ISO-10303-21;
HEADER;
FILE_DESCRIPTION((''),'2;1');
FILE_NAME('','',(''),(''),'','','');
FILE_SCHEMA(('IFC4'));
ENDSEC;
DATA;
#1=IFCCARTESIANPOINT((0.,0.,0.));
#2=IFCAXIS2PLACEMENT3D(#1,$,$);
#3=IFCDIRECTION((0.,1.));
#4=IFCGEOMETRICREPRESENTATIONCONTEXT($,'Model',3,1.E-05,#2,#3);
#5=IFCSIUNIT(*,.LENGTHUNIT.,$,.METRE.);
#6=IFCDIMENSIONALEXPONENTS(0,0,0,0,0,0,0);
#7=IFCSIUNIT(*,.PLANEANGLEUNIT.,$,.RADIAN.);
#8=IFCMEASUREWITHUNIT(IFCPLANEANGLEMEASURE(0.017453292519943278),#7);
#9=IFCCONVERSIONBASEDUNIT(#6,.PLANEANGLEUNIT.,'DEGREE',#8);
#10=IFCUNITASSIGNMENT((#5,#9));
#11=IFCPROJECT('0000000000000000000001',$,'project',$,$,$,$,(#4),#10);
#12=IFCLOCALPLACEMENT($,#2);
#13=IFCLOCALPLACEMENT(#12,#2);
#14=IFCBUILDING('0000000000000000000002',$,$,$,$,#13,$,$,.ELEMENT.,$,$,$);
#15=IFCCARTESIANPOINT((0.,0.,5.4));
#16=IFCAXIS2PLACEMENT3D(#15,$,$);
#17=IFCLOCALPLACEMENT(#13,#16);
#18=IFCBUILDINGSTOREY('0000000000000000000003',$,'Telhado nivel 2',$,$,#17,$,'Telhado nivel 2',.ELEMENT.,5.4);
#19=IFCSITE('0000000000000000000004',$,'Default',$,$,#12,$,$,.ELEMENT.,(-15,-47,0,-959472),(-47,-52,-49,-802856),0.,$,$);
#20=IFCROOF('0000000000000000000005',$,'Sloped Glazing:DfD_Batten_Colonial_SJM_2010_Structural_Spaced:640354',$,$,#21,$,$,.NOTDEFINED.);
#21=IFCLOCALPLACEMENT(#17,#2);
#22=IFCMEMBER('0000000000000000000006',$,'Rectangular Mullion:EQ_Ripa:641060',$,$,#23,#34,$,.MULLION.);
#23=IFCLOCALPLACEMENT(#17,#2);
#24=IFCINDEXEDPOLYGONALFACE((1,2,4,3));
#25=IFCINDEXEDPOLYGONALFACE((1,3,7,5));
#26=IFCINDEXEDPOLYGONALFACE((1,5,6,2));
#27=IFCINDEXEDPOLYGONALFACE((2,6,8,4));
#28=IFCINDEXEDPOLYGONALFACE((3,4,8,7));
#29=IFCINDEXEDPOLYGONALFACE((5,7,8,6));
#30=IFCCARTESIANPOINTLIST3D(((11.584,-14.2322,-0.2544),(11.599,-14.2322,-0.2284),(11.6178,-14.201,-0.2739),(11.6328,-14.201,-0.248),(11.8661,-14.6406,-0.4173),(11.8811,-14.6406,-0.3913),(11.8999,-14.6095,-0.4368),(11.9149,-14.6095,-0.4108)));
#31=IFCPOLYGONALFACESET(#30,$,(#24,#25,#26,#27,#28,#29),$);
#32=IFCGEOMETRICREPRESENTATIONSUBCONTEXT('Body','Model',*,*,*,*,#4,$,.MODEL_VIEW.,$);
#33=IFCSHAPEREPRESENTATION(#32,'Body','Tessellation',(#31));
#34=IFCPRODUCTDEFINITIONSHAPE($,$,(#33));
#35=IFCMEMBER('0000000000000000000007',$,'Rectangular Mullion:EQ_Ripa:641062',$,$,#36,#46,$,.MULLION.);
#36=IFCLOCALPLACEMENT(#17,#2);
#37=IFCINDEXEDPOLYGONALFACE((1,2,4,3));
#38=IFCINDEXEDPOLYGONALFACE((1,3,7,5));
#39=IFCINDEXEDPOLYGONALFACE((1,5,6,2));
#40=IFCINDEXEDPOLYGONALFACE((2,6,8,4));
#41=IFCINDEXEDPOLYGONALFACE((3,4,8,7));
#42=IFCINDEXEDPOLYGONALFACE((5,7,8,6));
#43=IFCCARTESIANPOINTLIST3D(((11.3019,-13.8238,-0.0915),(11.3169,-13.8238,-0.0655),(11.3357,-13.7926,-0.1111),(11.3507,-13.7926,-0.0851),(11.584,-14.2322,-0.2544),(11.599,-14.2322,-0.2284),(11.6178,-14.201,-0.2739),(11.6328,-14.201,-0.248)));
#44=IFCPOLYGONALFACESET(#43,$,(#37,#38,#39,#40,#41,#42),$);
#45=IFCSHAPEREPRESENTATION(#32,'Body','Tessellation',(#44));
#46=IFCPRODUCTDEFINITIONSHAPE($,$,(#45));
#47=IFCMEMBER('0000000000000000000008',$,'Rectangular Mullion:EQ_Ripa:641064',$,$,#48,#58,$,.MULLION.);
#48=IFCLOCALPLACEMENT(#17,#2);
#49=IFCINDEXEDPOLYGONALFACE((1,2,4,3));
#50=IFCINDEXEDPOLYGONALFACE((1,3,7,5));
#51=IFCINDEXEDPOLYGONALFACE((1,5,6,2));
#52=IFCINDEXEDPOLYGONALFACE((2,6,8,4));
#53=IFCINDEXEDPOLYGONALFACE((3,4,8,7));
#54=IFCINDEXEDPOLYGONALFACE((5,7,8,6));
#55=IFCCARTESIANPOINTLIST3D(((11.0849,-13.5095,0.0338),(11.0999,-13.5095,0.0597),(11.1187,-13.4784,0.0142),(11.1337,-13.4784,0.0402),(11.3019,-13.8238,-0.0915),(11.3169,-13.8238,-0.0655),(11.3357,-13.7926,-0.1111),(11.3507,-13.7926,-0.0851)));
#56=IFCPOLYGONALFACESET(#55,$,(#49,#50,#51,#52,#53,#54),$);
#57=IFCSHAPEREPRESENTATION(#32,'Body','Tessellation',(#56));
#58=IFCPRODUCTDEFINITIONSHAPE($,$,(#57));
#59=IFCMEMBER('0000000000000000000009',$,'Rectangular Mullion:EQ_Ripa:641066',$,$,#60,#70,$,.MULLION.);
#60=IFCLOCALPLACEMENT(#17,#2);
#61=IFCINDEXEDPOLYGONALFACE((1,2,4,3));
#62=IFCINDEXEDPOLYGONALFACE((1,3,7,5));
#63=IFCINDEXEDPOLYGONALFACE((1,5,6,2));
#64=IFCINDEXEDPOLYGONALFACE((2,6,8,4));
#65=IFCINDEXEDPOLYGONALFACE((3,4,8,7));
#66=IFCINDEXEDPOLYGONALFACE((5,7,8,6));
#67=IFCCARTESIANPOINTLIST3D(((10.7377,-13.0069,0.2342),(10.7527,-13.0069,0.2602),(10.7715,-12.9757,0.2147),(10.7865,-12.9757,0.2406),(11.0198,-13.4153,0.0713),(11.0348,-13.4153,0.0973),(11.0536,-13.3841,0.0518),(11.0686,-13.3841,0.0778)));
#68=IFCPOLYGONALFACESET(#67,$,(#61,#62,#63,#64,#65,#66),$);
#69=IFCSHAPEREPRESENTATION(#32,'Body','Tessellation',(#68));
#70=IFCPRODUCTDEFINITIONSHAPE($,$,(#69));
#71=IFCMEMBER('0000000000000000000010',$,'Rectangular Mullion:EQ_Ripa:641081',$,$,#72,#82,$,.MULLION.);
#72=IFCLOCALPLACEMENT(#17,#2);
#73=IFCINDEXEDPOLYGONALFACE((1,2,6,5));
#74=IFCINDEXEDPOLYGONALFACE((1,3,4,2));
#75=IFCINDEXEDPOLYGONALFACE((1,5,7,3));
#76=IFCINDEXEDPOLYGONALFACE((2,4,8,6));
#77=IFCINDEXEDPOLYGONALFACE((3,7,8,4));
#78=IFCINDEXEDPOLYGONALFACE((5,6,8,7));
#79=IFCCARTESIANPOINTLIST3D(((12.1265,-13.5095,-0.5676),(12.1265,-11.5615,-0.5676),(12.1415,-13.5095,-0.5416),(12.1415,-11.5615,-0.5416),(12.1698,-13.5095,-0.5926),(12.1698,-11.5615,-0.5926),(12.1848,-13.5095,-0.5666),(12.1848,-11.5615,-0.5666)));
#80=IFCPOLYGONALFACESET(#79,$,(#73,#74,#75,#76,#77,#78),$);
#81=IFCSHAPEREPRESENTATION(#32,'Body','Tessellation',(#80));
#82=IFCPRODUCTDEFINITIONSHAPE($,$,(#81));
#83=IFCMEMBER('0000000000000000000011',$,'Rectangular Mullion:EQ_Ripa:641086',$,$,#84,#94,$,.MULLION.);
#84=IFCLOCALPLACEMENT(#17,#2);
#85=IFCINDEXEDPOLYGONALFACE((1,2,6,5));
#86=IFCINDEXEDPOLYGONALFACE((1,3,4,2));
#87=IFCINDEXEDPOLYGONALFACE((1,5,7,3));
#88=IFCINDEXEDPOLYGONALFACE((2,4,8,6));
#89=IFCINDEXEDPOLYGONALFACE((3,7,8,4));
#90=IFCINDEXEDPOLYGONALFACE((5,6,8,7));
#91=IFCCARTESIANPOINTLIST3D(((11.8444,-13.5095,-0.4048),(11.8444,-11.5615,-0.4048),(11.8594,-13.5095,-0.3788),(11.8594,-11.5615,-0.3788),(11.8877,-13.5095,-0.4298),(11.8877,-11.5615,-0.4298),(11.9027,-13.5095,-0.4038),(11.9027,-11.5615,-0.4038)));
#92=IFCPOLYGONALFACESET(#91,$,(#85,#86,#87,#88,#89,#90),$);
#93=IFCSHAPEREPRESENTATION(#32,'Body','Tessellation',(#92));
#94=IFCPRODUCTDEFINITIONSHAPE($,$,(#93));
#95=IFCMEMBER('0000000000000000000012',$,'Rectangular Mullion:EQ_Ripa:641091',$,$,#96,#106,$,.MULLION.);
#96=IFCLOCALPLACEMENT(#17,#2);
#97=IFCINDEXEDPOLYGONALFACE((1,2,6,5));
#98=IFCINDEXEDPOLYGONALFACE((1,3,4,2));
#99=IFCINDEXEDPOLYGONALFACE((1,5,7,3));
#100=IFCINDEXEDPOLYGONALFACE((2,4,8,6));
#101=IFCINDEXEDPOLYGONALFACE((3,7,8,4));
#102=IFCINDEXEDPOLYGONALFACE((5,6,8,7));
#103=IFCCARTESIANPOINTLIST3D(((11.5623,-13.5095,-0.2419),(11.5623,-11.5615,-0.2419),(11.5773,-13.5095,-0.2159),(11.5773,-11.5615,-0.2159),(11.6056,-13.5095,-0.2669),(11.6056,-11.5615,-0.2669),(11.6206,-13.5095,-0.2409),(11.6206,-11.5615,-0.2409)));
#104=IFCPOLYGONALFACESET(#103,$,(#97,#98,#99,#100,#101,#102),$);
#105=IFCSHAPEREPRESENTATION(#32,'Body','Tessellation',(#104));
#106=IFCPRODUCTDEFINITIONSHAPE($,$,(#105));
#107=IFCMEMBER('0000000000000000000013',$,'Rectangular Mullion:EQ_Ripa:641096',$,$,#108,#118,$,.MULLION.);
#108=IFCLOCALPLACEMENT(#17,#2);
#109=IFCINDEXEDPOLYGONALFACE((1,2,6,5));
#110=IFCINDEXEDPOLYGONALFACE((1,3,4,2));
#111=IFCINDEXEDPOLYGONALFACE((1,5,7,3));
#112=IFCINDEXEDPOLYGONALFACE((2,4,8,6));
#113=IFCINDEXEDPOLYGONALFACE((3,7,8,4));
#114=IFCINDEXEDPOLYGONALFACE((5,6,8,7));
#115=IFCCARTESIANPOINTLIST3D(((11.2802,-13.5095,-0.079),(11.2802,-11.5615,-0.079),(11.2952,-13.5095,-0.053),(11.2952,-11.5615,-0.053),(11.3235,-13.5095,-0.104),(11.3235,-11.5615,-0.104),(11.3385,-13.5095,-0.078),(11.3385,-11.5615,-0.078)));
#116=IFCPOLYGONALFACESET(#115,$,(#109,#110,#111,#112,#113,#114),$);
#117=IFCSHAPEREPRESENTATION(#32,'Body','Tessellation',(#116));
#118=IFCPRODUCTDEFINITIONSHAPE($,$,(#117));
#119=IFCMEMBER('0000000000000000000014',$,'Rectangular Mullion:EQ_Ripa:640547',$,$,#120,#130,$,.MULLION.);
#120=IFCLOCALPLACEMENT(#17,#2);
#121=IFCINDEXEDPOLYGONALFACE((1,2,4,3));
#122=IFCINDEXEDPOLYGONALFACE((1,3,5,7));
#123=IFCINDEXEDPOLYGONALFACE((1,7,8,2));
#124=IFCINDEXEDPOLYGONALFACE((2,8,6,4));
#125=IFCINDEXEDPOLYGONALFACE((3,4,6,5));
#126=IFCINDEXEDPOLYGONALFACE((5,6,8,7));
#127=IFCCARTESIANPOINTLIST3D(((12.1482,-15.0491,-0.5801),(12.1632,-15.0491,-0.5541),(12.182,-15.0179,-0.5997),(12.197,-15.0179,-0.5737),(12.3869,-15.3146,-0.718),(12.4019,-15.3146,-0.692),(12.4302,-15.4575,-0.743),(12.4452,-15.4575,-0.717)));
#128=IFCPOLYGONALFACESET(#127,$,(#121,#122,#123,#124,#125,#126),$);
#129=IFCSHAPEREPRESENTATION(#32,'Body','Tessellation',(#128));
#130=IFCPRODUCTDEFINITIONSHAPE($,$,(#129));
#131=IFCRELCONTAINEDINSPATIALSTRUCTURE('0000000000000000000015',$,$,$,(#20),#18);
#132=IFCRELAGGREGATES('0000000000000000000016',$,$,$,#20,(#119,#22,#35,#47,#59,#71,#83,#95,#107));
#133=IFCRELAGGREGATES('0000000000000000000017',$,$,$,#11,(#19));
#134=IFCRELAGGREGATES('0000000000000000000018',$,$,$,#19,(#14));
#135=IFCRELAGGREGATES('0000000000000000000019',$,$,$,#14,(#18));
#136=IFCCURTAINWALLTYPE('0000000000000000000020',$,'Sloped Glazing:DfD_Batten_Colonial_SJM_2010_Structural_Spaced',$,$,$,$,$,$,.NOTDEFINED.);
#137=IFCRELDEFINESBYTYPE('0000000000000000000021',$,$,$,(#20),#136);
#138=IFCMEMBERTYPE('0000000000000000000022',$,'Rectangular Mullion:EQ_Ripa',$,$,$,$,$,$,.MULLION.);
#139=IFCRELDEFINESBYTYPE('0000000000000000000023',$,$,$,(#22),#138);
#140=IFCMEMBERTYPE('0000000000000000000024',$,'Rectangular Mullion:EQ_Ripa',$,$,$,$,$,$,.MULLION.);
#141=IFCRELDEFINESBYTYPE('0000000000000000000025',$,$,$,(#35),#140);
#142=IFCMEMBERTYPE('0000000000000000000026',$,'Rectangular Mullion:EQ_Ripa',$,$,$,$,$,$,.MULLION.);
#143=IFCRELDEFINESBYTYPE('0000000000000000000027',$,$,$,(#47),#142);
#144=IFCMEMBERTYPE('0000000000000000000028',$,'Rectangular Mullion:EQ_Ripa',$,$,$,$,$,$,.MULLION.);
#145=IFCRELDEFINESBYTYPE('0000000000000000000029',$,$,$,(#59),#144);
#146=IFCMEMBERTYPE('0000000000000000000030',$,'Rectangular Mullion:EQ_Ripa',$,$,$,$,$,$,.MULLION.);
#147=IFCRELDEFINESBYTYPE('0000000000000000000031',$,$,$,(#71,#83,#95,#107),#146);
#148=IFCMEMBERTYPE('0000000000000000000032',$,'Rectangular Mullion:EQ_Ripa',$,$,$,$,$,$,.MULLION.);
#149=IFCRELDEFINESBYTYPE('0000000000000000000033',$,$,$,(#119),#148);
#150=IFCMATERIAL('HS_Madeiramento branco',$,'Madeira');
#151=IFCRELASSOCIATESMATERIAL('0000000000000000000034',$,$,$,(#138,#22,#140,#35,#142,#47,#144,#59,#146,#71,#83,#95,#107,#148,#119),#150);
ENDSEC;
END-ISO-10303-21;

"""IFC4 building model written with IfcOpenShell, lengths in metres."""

from ifc_helpers import new_model, entity, si_unit, converted_unit, direction, frame, origin, place, context, subcontext, project, spatial, indexed_curve, outline, extrude, source, transform, mapped, material, type_object, type_shapes, element, aggregate, save


model = new_model("IFC4")

# Units and contexts
model_context = context("Model", 3, precision=1e-05, world=origin(), true_north=direction((0.0, 1.0)))
body_context = subcontext(model_context, "Body", "Model", "MODEL_VIEW")
ifc_project = project(units=[si_unit("LENGTHUNIT", "METRE"), converted_unit("PLANEANGLEUNIT", "DEGREE", entity("IfcPlaneAngleMeasure", 0.017453292519943278), si_unit("PLANEANGLEUNIT", "RADIAN"), dimensions=[0, 0, 0, 0, 0, 0, 0])], contexts=[model_context])

# Site, building, storey
site_placement = place(None, origin())
site = spatial("IfcSite", under=ifc_project, at=site_placement, Name="Default", CompositionType="ELEMENT", RefLatitude=(-15, -47, 0, -959472), RefLongitude=(-47, -52, -49, -802856), RefElevation=0.0)
building_placement = place(site_placement, origin())
building = spatial("IfcBuilding", under=site, at=building_placement, CompositionType="ELEMENT")
storey_placement = place(building_placement, frame((0.0, 0.0, 5.4)))
storey = spatial("IfcBuildingStorey", under=building, at=storey_placement, Name="Telhado nivel 2", LongName="Telhado nivel 2", CompositionType="ELEMENT", Elevation=5.4)

# Roof, members
ifc_material = material(Name="HS_Madeiramento branco", Category="Madeira")
curtain_wall_type_1 = type_object("IfcCurtainWallType", Name="Sloped Glazing:DfD_Batten_Colonial_SJM_2010_Structural_Spaced", PredefinedType="NOTDEFINED")
roof_1_placement = place(storey_placement, frame((0.0, 0.0, -5.4)))
roof_1 = element("IfcRoof", 1, at=roof_1_placement, inside=storey, type_object=curtain_wall_type_1, Name="Sloped Glazing:DfD_Batten_Colonial_SJM_2010_Structural_Spaced:640354", PredefinedType="NOTDEFINED")
member_type_1 = type_object("IfcMemberType", Name="Rectangular Mullion:EQ_Ripa", PredefinedType="MULLION", material=ifc_material)
shared_shape_1 = source(origin(), body_context, "Body", "SweptSolid", [
    extrude(outline(indexed_curve([(-0.025, -0.015), (0.025, -0.015), (0.025, 0.015), (-0.025, 0.015), (-0.025, -0.015)], self_intersect=False)), frame((-0.025, 0.0, -0.5224), z_axis=(0.0, 0.0, 1.0), x_axis=(-1.0, 0.0, 0.0)), (0.0, 0.0, 1.0), 0.5224),
])
type_shapes(member_type_1, [shared_shape_1])
member_1_placement = place(roof_1_placement, frame((11.8736, -14.6406, 4.9957), z_axis=(0.539965, -0.781825, -0.311749), x_axis=(-0.67708, -0.623498, 0.390913)))
member_1 = element("IfcMember", 2, at=member_1_placement, type_object=member_type_1, material=ifc_material, Name="Rectangular Mullion:EQ_Ripa:641060", PredefinedType="MULLION", context=body_context, shape_type="MappedRepresentation", body=[
    mapped(shared_shape_1, transform((0.0, 0.0, 0.0), scale=1.0)),
])
member_type_2 = type_object("IfcMemberType", Name="Rectangular Mullion:EQ_Ripa", PredefinedType="MULLION", material=ifc_material)
shared_shape_2 = source(origin(), body_context, "Body", "SweptSolid", [
    extrude(outline(indexed_curve([(-0.025, -0.015), (0.025, -0.015), (0.025, 0.015), (-0.025, 0.015), (-0.025, -0.015)], self_intersect=False)), frame((-0.025, 0.0, -0.5224), z_axis=(0.0, 0.0, 1.0), x_axis=(-1.0, 0.0, 0.0)), (0.0, 0.0, 1.0), 0.5224),
])
type_shapes(member_type_2, [shared_shape_2])
member_2_placement = place(roof_1_placement, frame((11.5915, -14.2322, 5.1586), z_axis=(0.539965, -0.781825, -0.311749), x_axis=(-0.67708, -0.623498, 0.390913)))
member_2 = element("IfcMember", 3, at=member_2_placement, type_object=member_type_2, material=ifc_material, Name="Rectangular Mullion:EQ_Ripa:641062", PredefinedType="MULLION", context=body_context, shape_type="MappedRepresentation", body=[
    mapped(shared_shape_2, transform((0.0, 0.0, 0.0), scale=1.0)),
])
member_type_3 = type_object("IfcMemberType", Name="Rectangular Mullion:EQ_Ripa", PredefinedType="MULLION", material=ifc_material)
shared_shape_3 = source(origin(), body_context, "Body", "SweptSolid", [
    extrude(outline(indexed_curve([(-0.025, -0.015), (0.025, -0.015), (0.025, 0.015), (-0.025, 0.015), (-0.025, -0.015)], self_intersect=False)), frame((-0.025, 0.0, -0.4019), z_axis=(0.0, 0.0, 1.0), x_axis=(-1.0, 0.0, 0.0)), (0.0, 0.0, 1.0), 0.4019),
])
type_shapes(member_type_3, [shared_shape_3])
member_3_placement = place(roof_1_placement, frame((11.3094, -13.8238, 5.3215), z_axis=(0.539965, -0.781825, -0.311749), x_axis=(-0.67708, -0.623498, 0.390913)))
member_3 = element("IfcMember", 4, at=member_3_placement, type_object=member_type_3, material=ifc_material, Name="Rectangular Mullion:EQ_Ripa:641064", PredefinedType="MULLION", context=body_context, shape_type="MappedRepresentation", body=[
    mapped(shared_shape_3, transform((0.0, 0.0, 0.0), scale=1.0)),
])
member_type_4 = type_object("IfcMemberType", Name="Rectangular Mullion:EQ_Ripa", PredefinedType="MULLION", material=ifc_material)
shared_shape_4 = source(origin(), body_context, "Body", "SweptSolid", [
    extrude(outline(indexed_curve([(-0.025, -0.015), (0.025, -0.015), (0.025, 0.015), (-0.025, 0.015), (-0.025, -0.015)], self_intersect=False)), frame((-0.025, 0.0, -0.5224), z_axis=(0.0, 0.0, 1.0), x_axis=(-1.0, 0.0, 0.0)), (0.0, 0.0, 1.0), 0.5224),
])
type_shapes(member_type_4, [shared_shape_4])
member_4_placement = place(roof_1_placement, frame((11.0273, -13.4153, 5.4843), z_axis=(0.539965, -0.781825, -0.311749), x_axis=(-0.67708, -0.623498, 0.390913)))
member_4 = element("IfcMember", 5, at=member_4_placement, type_object=member_type_4, material=ifc_material, Name="Rectangular Mullion:EQ_Ripa:641066", PredefinedType="MULLION", context=body_context, shape_type="MappedRepresentation", body=[
    mapped(shared_shape_4, transform((0.0, 0.0, 0.0), scale=1.0)),
])
member_type_5 = type_object("IfcMemberType", Name="Rectangular Mullion:EQ_Ripa", PredefinedType="MULLION", material=ifc_material)
shared_shape_5 = source(origin(), body_context, "Body", "SweptSolid", [
    extrude(outline(indexed_curve([(-0.025, -0.015), (0.025, -0.015), (0.025, 0.015), (-0.025, 0.015), (-0.025, -0.015)], self_intersect=False)), frame((0.0, 0.0, -1.948), z_axis=(0.0, 0.0, 1.0), x_axis=(-1.0, 0.0, 0.0)), (0.0, 0.0, 1.0), 1.948),
])
type_shapes(member_type_5, [shared_shape_5])
member_5_placement = place(roof_1_placement, frame((12.1557, -13.5095, 4.8329), z_axis=(0.0, -1.0, 0.0), x_axis=(-0.866025, 0.0, 0.5)))
member_5 = element("IfcMember", 6, at=member_5_placement, type_object=member_type_5, material=ifc_material, Name="Rectangular Mullion:EQ_Ripa:641081", PredefinedType="MULLION", context=body_context, shape_type="MappedRepresentation", body=[
    mapped(shared_shape_5, transform((0.0, 0.0, 0.0), scale=1.0)),
])
member_6_placement = place(roof_1_placement, frame((11.8736, -13.5095, 4.9957), z_axis=(0.0, -1.0, 0.0), x_axis=(-0.866025, 0.0, 0.5)))
member_6 = element("IfcMember", 7, at=member_6_placement, type_object=member_type_5, material=ifc_material, Name="Rectangular Mullion:EQ_Ripa:641086", PredefinedType="MULLION", context=body_context, shape_type="MappedRepresentation", body=[
    mapped(shared_shape_5, transform((0.0, 0.0, 0.0), scale=1.0)),
])
member_7_placement = place(roof_1_placement, frame((11.5915, -13.5095, 5.1586), z_axis=(0.0, -1.0, 0.0), x_axis=(-0.866025, 0.0, 0.5)))
member_7 = element("IfcMember", 8, at=member_7_placement, type_object=member_type_5, material=ifc_material, Name="Rectangular Mullion:EQ_Ripa:641091", PredefinedType="MULLION", context=body_context, shape_type="MappedRepresentation", body=[
    mapped(shared_shape_5, transform((0.0, 0.0, 0.0), scale=1.0)),
])
member_8_placement = place(roof_1_placement, frame((11.3094, -13.5095, 5.3215), z_axis=(0.0, -1.0, 0.0), x_axis=(-0.866025, 0.0, 0.5)))
member_8 = element("IfcMember", 9, at=member_8_placement, type_object=member_type_5, material=ifc_material, Name="Rectangular Mullion:EQ_Ripa:641096", PredefinedType="MULLION", context=body_context, shape_type="MappedRepresentation", body=[
    mapped(shared_shape_5, transform((0.0, 0.0, 0.0), scale=1.0)),
])
member_type_6 = type_object("IfcMemberType", Name="Rectangular Mullion:EQ_Ripa", PredefinedType="MULLION", material=ifc_material)
shared_shape_6 = source(origin(), body_context, "Body", "SweptSolid", [
    extrude(outline(indexed_curve([(-0.2969, -0.025), (0.2255, -0.025), (0.2255, 0.025), (-0.154, 0.025), (-0.2969, -0.025)], self_intersect=False)), frame((-0.025, -0.015, -0.2969), z_axis=(0.0, 1.0, 0.0), x_axis=(0.0, 0.0, -1.0)), (0.0, 0.0, 1.0), 0.03),
])
type_shapes(member_type_6, [shared_shape_6])
member_9_placement = place(roof_1_placement, frame((12.4377, -15.4575, 4.67), z_axis=(0.539965, -0.781825, -0.311749), x_axis=(-0.67708, -0.623498, 0.390913)))
member_9 = element("IfcMember", 10, at=member_9_placement, type_object=member_type_6, material=ifc_material, Name="Rectangular Mullion:EQ_Ripa:640547", PredefinedType="MULLION", context=body_context, shape_type="MappedRepresentation", body=[
    mapped(shared_shape_6, transform((0.0, 0.0, 0.0), scale=1.0)),
])
aggregate(roof_1, [member_9, member_1, member_2, member_3, member_4, member_5, member_6, member_7, member_8])

save(model, "model.ifc")
